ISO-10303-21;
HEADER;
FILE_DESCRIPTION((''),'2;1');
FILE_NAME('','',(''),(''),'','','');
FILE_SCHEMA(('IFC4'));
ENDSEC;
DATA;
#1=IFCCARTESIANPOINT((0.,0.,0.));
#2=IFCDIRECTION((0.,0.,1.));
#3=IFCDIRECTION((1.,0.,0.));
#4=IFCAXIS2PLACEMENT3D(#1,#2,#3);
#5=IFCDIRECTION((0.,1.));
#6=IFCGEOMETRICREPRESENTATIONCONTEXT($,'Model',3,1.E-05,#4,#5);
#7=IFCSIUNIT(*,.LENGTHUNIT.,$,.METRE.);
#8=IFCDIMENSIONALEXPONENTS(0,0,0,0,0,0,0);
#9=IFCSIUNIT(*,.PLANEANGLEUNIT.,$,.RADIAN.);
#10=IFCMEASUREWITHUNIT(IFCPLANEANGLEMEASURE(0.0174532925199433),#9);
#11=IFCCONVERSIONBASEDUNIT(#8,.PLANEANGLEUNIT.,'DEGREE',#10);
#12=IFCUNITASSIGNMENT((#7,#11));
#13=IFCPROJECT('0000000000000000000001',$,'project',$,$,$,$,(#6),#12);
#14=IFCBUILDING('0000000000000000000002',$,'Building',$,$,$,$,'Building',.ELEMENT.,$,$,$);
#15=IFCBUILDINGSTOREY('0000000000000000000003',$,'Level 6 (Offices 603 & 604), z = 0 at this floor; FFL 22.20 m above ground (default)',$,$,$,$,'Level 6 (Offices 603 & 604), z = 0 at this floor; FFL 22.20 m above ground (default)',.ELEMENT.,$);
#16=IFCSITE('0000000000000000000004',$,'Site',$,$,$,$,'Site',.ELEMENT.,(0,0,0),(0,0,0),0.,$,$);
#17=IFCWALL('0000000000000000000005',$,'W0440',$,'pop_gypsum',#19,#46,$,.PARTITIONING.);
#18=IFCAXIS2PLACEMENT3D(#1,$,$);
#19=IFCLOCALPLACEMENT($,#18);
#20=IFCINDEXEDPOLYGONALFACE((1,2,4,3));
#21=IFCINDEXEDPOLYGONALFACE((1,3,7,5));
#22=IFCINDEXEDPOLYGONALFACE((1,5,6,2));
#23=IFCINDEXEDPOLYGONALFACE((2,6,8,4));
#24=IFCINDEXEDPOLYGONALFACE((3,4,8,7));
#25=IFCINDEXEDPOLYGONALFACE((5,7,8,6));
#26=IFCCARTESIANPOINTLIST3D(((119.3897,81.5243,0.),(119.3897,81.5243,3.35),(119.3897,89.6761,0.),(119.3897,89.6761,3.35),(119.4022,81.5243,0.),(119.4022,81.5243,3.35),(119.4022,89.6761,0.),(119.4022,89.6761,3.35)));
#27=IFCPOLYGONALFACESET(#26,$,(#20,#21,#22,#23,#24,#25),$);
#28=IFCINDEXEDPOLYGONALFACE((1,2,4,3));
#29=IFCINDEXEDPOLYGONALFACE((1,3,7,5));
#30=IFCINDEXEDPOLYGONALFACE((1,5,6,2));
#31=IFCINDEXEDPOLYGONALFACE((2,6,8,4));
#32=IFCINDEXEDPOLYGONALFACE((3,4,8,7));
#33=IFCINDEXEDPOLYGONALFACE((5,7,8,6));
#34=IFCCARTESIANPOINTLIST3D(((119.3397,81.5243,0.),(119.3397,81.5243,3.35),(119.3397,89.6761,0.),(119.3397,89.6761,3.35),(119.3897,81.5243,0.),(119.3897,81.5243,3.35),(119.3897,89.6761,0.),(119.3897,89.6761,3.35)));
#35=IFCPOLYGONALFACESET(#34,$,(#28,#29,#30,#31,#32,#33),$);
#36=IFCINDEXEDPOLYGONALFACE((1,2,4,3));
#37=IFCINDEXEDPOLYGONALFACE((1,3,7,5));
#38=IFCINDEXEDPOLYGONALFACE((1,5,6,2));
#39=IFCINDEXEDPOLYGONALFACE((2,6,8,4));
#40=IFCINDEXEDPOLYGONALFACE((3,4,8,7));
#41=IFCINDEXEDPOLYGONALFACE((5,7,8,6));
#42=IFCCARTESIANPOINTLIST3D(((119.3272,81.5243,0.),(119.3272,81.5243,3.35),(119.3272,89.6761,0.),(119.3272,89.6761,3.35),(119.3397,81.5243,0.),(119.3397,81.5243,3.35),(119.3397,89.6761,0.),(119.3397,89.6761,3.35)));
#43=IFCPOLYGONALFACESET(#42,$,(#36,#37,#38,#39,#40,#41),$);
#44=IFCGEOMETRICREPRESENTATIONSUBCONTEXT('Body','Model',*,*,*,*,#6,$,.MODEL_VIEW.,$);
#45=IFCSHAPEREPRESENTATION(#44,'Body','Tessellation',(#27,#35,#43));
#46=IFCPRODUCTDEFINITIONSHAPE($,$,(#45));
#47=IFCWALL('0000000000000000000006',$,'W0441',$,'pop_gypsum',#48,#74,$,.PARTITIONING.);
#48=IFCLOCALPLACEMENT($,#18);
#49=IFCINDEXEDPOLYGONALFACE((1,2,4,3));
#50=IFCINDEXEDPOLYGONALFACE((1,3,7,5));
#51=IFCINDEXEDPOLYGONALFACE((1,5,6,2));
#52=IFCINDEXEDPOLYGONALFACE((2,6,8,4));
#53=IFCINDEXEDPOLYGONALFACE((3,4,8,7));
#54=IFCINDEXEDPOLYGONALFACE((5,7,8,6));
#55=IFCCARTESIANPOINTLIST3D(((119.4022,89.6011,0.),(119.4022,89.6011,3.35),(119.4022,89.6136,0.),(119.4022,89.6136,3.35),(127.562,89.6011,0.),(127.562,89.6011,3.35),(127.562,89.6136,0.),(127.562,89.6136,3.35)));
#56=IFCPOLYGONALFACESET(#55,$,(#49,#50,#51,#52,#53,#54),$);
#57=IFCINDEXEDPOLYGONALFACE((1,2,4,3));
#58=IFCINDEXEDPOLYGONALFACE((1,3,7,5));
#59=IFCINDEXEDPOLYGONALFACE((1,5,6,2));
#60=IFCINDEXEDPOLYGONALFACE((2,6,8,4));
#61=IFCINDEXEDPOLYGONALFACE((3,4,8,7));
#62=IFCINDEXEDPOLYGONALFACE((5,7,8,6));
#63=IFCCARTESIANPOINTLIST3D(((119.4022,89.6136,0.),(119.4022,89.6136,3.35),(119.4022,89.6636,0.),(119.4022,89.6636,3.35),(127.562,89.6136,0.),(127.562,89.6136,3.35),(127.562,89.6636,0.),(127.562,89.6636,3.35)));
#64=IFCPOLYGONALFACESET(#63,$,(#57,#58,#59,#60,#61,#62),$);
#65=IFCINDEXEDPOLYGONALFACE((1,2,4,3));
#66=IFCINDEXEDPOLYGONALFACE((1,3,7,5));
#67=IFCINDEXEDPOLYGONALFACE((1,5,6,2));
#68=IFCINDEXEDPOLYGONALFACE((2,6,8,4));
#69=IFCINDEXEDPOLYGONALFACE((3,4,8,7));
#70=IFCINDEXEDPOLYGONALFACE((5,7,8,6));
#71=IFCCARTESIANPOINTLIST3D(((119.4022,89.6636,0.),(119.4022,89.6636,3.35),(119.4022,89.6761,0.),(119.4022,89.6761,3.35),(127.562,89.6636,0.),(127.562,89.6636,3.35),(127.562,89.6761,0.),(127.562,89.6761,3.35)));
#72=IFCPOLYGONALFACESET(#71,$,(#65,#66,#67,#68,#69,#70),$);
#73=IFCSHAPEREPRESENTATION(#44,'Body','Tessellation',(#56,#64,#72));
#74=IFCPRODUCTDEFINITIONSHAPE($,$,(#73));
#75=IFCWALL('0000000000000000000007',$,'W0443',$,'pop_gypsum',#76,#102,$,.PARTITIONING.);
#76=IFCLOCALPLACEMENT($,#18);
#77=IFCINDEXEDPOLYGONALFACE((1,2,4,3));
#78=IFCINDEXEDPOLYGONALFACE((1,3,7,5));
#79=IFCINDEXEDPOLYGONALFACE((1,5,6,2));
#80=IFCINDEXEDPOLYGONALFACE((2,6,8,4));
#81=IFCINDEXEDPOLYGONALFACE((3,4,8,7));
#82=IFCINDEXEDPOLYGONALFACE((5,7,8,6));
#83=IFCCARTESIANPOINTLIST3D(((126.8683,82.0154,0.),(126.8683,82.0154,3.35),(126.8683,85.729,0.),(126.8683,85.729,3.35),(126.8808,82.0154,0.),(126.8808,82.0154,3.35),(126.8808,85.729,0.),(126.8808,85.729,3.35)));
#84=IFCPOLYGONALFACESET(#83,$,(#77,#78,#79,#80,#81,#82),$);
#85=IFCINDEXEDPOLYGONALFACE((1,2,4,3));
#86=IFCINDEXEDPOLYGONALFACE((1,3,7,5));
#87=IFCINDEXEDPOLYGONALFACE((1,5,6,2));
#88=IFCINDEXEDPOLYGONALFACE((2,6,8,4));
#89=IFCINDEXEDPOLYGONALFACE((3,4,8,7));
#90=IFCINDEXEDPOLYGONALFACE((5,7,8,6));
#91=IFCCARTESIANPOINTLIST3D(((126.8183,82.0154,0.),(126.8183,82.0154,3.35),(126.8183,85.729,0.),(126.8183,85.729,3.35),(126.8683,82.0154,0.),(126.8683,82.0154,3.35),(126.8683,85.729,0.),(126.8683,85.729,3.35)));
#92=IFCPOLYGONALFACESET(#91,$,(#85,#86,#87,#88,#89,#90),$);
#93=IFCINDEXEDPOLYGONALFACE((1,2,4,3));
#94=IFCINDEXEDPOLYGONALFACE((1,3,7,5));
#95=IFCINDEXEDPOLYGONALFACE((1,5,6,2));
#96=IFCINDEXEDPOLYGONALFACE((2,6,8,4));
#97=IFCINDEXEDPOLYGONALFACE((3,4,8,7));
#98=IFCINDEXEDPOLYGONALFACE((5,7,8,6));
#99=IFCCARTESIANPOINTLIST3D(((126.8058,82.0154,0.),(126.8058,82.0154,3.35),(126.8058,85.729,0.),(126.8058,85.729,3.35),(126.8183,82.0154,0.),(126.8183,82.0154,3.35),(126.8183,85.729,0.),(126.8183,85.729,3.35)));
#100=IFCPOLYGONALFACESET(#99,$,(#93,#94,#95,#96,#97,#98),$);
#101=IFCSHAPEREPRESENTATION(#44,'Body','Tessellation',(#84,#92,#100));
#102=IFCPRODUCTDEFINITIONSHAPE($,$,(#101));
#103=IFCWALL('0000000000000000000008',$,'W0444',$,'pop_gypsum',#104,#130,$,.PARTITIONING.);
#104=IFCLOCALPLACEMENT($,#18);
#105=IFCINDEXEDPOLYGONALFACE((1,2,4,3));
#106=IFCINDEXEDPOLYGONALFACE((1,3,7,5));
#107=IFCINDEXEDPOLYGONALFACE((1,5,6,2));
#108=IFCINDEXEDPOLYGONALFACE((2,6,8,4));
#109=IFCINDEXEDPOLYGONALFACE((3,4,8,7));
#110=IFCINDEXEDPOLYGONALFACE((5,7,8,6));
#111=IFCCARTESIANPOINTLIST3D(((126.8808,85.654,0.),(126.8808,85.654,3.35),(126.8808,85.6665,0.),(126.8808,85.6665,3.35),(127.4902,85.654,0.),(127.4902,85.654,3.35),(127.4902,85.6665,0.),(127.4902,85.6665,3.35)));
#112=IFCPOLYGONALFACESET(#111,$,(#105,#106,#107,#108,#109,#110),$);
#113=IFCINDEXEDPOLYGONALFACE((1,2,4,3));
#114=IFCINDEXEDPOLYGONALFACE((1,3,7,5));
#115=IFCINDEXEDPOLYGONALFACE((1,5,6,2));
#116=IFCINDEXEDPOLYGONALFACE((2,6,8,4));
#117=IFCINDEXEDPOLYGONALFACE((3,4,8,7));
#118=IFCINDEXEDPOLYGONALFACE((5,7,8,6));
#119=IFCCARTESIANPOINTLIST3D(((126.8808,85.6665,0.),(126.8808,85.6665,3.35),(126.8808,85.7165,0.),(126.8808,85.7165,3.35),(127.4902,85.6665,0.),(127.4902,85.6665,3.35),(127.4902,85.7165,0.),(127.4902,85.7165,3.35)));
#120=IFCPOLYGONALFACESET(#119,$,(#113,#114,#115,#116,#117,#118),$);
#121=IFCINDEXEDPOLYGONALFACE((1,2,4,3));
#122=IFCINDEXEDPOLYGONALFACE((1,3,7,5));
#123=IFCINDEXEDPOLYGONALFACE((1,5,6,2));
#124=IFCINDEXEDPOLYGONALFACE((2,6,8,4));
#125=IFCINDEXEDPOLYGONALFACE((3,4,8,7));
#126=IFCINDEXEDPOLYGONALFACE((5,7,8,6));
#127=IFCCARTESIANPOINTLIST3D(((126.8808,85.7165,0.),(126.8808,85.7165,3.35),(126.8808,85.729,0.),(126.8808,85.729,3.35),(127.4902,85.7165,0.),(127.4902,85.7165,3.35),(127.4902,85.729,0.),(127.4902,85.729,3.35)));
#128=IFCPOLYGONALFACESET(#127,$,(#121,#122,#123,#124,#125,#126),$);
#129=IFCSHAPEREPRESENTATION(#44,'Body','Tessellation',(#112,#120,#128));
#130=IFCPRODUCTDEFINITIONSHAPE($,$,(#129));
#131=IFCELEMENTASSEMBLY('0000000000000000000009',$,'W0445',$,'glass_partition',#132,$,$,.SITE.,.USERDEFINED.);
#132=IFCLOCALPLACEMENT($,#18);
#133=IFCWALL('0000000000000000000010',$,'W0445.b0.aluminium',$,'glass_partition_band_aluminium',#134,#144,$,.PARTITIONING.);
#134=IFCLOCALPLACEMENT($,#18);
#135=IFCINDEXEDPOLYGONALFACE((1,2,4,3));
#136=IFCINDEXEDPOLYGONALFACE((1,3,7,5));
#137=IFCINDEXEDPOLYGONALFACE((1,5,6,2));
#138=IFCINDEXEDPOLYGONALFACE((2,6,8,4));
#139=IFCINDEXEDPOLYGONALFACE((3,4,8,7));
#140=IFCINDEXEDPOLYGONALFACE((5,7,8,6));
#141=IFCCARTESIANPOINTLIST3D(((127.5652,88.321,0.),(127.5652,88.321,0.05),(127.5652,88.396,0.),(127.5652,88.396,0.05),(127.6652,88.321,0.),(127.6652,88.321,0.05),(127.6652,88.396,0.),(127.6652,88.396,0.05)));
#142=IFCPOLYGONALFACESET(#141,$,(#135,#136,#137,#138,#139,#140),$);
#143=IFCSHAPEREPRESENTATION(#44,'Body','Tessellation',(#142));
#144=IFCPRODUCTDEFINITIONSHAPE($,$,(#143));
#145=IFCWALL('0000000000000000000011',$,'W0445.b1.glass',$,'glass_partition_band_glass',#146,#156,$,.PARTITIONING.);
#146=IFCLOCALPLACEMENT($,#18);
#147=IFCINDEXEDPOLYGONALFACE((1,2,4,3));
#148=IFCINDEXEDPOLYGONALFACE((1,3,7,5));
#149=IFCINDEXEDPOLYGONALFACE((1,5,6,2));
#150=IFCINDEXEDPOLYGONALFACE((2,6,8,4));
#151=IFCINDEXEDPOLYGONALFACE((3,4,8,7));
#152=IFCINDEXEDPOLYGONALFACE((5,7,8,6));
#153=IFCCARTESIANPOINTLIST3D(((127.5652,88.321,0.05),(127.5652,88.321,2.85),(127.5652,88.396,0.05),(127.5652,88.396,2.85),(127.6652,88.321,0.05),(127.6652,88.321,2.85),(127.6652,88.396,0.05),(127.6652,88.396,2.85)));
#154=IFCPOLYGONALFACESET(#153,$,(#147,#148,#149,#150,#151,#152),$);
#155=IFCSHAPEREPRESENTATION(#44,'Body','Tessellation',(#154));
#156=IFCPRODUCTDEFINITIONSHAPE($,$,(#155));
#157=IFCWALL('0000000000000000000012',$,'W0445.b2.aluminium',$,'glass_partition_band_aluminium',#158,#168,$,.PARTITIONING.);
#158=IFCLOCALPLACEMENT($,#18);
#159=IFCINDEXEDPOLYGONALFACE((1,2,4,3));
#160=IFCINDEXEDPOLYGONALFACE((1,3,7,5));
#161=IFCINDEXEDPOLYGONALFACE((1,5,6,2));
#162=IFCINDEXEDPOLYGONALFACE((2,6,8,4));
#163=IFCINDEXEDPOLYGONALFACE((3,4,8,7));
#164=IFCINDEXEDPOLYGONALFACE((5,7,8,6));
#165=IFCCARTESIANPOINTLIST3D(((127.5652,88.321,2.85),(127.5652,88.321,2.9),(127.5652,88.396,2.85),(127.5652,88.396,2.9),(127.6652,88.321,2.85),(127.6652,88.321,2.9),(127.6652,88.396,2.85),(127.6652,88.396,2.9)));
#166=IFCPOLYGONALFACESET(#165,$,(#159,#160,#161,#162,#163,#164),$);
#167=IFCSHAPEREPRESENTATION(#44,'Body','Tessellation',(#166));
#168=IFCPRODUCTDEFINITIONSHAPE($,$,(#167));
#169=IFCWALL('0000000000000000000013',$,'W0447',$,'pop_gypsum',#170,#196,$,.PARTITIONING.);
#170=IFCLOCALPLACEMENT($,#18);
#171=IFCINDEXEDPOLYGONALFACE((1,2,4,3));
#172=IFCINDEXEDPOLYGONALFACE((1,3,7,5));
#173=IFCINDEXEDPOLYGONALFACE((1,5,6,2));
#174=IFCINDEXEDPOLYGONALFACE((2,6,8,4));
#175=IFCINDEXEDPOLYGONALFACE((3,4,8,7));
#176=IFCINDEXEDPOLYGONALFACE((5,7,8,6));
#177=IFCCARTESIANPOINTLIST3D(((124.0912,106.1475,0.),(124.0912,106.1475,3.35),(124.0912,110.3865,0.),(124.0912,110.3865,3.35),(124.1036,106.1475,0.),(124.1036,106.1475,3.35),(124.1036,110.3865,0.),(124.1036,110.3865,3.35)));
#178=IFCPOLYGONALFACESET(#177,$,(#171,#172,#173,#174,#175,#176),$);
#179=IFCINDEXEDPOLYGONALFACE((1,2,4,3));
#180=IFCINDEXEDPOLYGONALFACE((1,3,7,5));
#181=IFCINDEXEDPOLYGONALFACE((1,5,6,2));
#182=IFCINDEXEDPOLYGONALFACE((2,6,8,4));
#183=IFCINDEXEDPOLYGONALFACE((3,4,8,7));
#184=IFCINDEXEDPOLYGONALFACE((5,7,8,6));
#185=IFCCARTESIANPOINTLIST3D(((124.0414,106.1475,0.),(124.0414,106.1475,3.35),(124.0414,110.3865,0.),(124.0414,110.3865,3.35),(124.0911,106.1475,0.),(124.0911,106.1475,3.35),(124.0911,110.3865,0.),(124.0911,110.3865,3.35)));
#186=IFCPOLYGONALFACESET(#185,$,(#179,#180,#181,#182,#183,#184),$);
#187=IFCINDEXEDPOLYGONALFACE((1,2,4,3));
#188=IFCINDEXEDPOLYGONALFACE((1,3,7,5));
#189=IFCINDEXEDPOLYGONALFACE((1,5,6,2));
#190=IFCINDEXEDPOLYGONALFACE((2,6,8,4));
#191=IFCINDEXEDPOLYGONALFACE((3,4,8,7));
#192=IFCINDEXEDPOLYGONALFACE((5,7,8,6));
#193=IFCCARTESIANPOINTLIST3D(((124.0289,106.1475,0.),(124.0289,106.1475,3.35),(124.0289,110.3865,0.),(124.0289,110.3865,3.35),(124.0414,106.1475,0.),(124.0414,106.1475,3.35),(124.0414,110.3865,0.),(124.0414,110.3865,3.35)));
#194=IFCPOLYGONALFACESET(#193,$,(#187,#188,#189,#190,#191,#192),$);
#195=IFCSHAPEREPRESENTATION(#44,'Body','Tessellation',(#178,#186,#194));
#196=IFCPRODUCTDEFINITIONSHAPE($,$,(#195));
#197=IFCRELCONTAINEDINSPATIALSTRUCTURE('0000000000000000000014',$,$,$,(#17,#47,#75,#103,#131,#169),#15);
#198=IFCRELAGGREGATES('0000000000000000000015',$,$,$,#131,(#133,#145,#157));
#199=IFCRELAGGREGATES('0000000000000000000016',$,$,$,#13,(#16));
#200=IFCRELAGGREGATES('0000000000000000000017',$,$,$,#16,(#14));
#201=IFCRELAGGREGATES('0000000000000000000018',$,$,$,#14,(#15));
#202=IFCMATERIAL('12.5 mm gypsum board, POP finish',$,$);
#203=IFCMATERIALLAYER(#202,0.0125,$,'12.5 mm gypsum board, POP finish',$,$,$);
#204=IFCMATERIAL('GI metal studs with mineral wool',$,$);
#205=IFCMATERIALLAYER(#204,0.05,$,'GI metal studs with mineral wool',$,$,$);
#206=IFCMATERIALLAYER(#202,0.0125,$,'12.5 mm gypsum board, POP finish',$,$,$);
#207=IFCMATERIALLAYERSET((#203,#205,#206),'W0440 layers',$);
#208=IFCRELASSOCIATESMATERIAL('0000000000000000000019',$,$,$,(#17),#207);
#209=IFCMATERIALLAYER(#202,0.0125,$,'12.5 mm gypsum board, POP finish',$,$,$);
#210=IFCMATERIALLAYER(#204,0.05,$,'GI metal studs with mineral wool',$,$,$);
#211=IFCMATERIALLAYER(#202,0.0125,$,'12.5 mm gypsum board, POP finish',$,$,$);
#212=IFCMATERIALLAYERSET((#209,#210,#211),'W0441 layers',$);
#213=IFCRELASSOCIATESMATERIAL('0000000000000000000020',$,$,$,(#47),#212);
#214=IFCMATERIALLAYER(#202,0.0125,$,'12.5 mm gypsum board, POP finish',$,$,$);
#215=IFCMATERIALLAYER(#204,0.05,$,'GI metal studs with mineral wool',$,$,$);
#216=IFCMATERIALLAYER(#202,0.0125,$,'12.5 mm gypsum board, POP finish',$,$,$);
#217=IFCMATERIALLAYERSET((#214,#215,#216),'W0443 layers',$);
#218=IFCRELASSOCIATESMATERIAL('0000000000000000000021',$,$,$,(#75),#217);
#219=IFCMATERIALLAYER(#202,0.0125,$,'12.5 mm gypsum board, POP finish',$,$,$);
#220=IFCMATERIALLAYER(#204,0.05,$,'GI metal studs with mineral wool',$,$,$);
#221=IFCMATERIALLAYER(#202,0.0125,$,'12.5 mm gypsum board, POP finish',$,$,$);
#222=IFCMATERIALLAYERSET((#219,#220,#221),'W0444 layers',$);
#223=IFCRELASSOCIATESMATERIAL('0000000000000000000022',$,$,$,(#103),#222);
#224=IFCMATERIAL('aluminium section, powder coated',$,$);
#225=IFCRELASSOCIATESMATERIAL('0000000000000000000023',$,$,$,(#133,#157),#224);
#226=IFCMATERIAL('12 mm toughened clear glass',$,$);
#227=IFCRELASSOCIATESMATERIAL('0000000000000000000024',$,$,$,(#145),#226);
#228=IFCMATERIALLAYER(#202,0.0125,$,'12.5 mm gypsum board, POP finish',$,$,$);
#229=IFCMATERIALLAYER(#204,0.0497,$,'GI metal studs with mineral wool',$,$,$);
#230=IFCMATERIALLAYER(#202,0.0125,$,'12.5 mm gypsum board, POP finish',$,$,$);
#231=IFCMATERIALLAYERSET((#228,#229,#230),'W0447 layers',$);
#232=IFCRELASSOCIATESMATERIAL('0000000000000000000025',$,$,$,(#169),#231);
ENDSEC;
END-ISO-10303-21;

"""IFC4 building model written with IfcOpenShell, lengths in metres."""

from ifc_helpers import new_model, entity, si_unit, converted_unit, direction, frame, frame_2d, origin_with_axes, origin_2d_with_axis, place, context, subcontext, project, spatial, rectangle, extrude, material, layer, layer_set, layer_usage, element, aggregate, save


model = new_model("IFC4")

# Units and contexts
model_context = context("Model", 3, precision=1e-05, world=origin_with_axes(), true_north=direction((0.0, 1.0)))
body_context = subcontext(model_context, "Body", "Model", "MODEL_VIEW")
ifc_project = project(units=[si_unit("LENGTHUNIT", "METRE"), converted_unit("PLANEANGLEUNIT", "DEGREE", entity("IfcPlaneAngleMeasure", 0.0174532925199433), si_unit("PLANEANGLEUNIT", "RADIAN"), dimensions=[0, 0, 0, 0, 0, 0, 0])], contexts=[model_context])

# Site, building, storey
site = spatial("IfcSite", under=ifc_project, Name="Site", LongName="Site", CompositionType="ELEMENT", RefLatitude=(0, 0, 0), RefLongitude=(0, 0, 0), RefElevation=0.0)
building = spatial("IfcBuilding", under=site, Name="Building", LongName="Building", CompositionType="ELEMENT")
storey = spatial("IfcBuildingStorey", under=building, Name="Level 6 (Offices 603 & 604), z = 0 at this floor; FFL 22.20 m above ground (default)", LongName="Level 6 (Offices 603 & 604), z = 0 at this floor; FFL 22.20 m above ground (default)", CompositionType="ELEMENT")

# Shared definitions
ifc_material_1 = material(Name="aluminium section, powder coated")
placement = place(None, origin_with_axes())

# Shared definitions
ifc_material_2 = material(Name="12.5 mm gypsum board, POP finish")
ifc_material_3 = material(Name="GI metal studs with mineral wool")

# Shared definitions
ifc_material_4 = material(Name="12 mm toughened clear glass")

# Walls
ifc_layer_1 = layer(ifc_material_2, 0.0125, Name="12.5 mm gypsum board, POP finish")
ifc_layer_2 = layer(ifc_material_3, 0.05, Name="GI metal studs with mineral wool")
ifc_layer_3 = layer(ifc_material_2, 0.0125, Name="12.5 mm gypsum board, POP finish")
ifc_layer_set_1 = layer_set([ifc_layer_1, ifc_layer_2, ifc_layer_3], Name="W0440 layers")
ifc_layer_usage_1 = layer_usage(ifc_layer_set_1, "AXIS2", "POSITIVE", -0.0375)
element("IfcWall", 1, at=placement, inside=storey, material=ifc_layer_usage_1, Name="W0440", ObjectType="pop_gypsum", PredefinedType="PARTITIONING", context=body_context, shape_type="SweptSolid", body=[
    extrude(rectangle(XDim=8.1518, YDim=0.0125, at=frame_2d((0.0, 0.0), x_axis=(0.0, 1.0))), frame((119.3959, 85.6002, 0.0), z_axis=(0.0, 0.0, 1.0), x_axis=(1.0, 0.0, 0.0)), (0.0, 0.0, 1.0), 3.35),
    extrude(rectangle(XDim=8.1518, YDim=0.05, at=frame_2d((-0.0312, 0.0), x_axis=(0.0, 1.0))), frame((119.3959, 85.6002, 0.0), z_axis=(0.0, 0.0, 1.0), x_axis=(1.0, 0.0, 0.0)), (0.0, 0.0, 1.0), 3.35),
    extrude(rectangle(XDim=8.1518, YDim=0.0125, at=frame_2d((-0.0625, 0.0), x_axis=(0.0, 1.0))), frame((119.3959, 85.6002, 0.0), z_axis=(0.0, 0.0, 1.0), x_axis=(1.0, 0.0, 0.0)), (0.0, 0.0, 1.0), 3.35),
])
ifc_layer_4 = layer(ifc_material_2, 0.0125, Name="12.5 mm gypsum board, POP finish")
ifc_layer_5 = layer(ifc_material_3, 0.05, Name="GI metal studs with mineral wool")
ifc_layer_6 = layer(ifc_material_2, 0.0125, Name="12.5 mm gypsum board, POP finish")
ifc_layer_set_2 = layer_set([ifc_layer_4, ifc_layer_5, ifc_layer_6], Name="W0441 layers")
ifc_layer_usage_2 = layer_usage(ifc_layer_set_2, "AXIS2", "POSITIVE", -0.0375)
element("IfcWall", 2, at=placement, inside=storey, material=ifc_layer_usage_2, Name="W0441", ObjectType="pop_gypsum", PredefinedType="PARTITIONING", context=body_context, shape_type="SweptSolid", body=[
    extrude(rectangle(XDim=8.1598, YDim=0.0125, at=frame_2d((0.0, 0.0), x_axis=(1.0, 0.0))), frame((123.4821, 89.6073, 0.0), z_axis=(0.0, 0.0, 1.0), x_axis=(1.0, 0.0, 0.0)), (0.0, 0.0, 1.0), 3.35),
    extrude(rectangle(XDim=8.1598, YDim=0.05, at=frame_2d((0.0, 0.0312), x_axis=(1.0, 0.0))), frame((123.4821, 89.6073, 0.0), z_axis=(0.0, 0.0, 1.0), x_axis=(1.0, 0.0, 0.0)), (0.0, 0.0, 1.0), 3.35),
    extrude(rectangle(XDim=8.1598, YDim=0.0125, at=frame_2d((0.0, 0.0625), x_axis=(1.0, 0.0))), frame((123.4821, 89.6073, 0.0), z_axis=(0.0, 0.0, 1.0), x_axis=(1.0, 0.0, 0.0)), (0.0, 0.0, 1.0), 3.35),
])
ifc_layer_7 = layer(ifc_material_2, 0.0125, Name="12.5 mm gypsum board, POP finish")
ifc_layer_8 = layer(ifc_material_3, 0.05, Name="GI metal studs with mineral wool")
ifc_layer_9 = layer(ifc_material_2, 0.0125, Name="12.5 mm gypsum board, POP finish")
ifc_layer_set_3 = layer_set([ifc_layer_7, ifc_layer_8, ifc_layer_9], Name="W0443 layers")
ifc_layer_usage_3 = layer_usage(ifc_layer_set_3, "AXIS2", "POSITIVE", -0.0375)
element("IfcWall", 3, at=placement, inside=storey, material=ifc_layer_usage_3, Name="W0443", ObjectType="pop_gypsum", PredefinedType="PARTITIONING", context=body_context, shape_type="SweptSolid", body=[
    extrude(rectangle(XDim=3.7136, YDim=0.0125, at=frame_2d((0.0, 0.0), x_axis=(0.0, 1.0))), frame((126.8745, 83.8722, 0.0), z_axis=(0.0, 0.0, 1.0), x_axis=(1.0, 0.0, 0.0)), (0.0, 0.0, 1.0), 3.35),
    extrude(rectangle(XDim=3.7136, YDim=0.05, at=frame_2d((-0.0312, 0.0), x_axis=(0.0, 1.0))), frame((126.8745, 83.8722, 0.0), z_axis=(0.0, 0.0, 1.0), x_axis=(1.0, 0.0, 0.0)), (0.0, 0.0, 1.0), 3.35),
    extrude(rectangle(XDim=3.7136, YDim=0.0125, at=frame_2d((-0.0625, 0.0), x_axis=(0.0, 1.0))), frame((126.8745, 83.8722, 0.0), z_axis=(0.0, 0.0, 1.0), x_axis=(1.0, 0.0, 0.0)), (0.0, 0.0, 1.0), 3.35),
])
ifc_layer_10 = layer(ifc_material_2, 0.0125, Name="12.5 mm gypsum board, POP finish")
ifc_layer_11 = layer(ifc_material_3, 0.05, Name="GI metal studs with mineral wool")
ifc_layer_12 = layer(ifc_material_2, 0.0125, Name="12.5 mm gypsum board, POP finish")
ifc_layer_set_4 = layer_set([ifc_layer_10, ifc_layer_11, ifc_layer_12], Name="W0444 layers")
ifc_layer_usage_4 = layer_usage(ifc_layer_set_4, "AXIS2", "POSITIVE", -0.0375)
element("IfcWall", 4, at=placement, inside=storey, material=ifc_layer_usage_4, Name="W0444", ObjectType="pop_gypsum", PredefinedType="PARTITIONING", context=body_context, shape_type="SweptSolid", body=[
    extrude(rectangle(XDim=0.6094, YDim=0.0125, at=origin_2d_with_axis()), frame((127.1855, 85.6603, 0.0), z_axis=(0.0, 0.0, 1.0), x_axis=(1.0, 0.0, 0.0)), (0.0, 0.0, 1.0), 3.35),
    extrude(rectangle(XDim=0.6094, YDim=0.05, at=frame_2d((0.0, 0.0313), x_axis=(1.0, 0.0))), frame((127.1855, 85.6603, 0.0), z_axis=(0.0, 0.0, 1.0), x_axis=(1.0, 0.0, 0.0)), (0.0, 0.0, 1.0), 3.35),
    extrude(rectangle(XDim=0.6094, YDim=0.0125, at=frame_2d((0.0, 0.0625), x_axis=(1.0, 0.0))), frame((127.1855, 85.6603, 0.0), z_axis=(0.0, 0.0, 1.0), x_axis=(1.0, 0.0, 0.0)), (0.0, 0.0, 1.0), 3.35),
])

# Element assembly, walls
assembly_1 = element("IfcElementAssembly", 5, inside=storey, Name="W0445", ObjectType="glass_partition", AssemblyPlace="SITE", PredefinedType="USERDEFINED")
wall_1 = element("IfcWall", 6, at=placement, material=ifc_material_1, Name="W0445.b0.aluminium", ObjectType="glass_partition_band_aluminium", PredefinedType="PARTITIONING", context=body_context, shape_type="SweptSolid", body=[
    extrude(rectangle(XDim=0.1, YDim=0.075, at=frame_2d((0.0, 0.0), x_axis=(1.0, 0.0))), frame((127.6152, 88.3585, 0.0), z_axis=(0.0, 0.0, 1.0), x_axis=(1.0, 0.0, 0.0)), (0.0, 0.0, 1.0), 0.05),
])
wall_2 = element("IfcWall", 7, at=placement, material=ifc_material_4, Name="W0445.b1.glass", ObjectType="glass_partition_band_glass", PredefinedType="PARTITIONING", context=body_context, shape_type="SweptSolid", body=[
    extrude(rectangle(XDim=0.1, YDim=0.075, at=frame_2d((0.0, 0.0), x_axis=(1.0, 0.0))), frame((127.6152, 88.3585, 0.05), z_axis=(0.0, 0.0, 1.0), x_axis=(1.0, 0.0, 0.0)), (0.0, 0.0, 1.0), 2.8),
])
wall_3 = element("IfcWall", 8, at=placement, material=ifc_material_1, Name="W0445.b2.aluminium", ObjectType="glass_partition_band_aluminium", PredefinedType="PARTITIONING", context=body_context, shape_type="SweptSolid", body=[
    extrude(rectangle(XDim=0.1, YDim=0.075, at=frame_2d((0.0, 0.0), x_axis=(1.0, 0.0))), frame((127.6152, 88.3585, 2.85), z_axis=(0.0, 0.0, 1.0), x_axis=(1.0, 0.0, 0.0)), (0.0, 0.0, 1.0), 0.05),
])
aggregate(assembly_1, [wall_1, wall_2, wall_3])

# Wall
ifc_layer_13 = layer(ifc_material_2, 0.0125, Name="12.5 mm gypsum board, POP finish")
ifc_layer_14 = layer(ifc_material_3, 0.0497, Name="GI metal studs with mineral wool")
ifc_layer_15 = layer(ifc_material_2, 0.0125, Name="12.5 mm gypsum board, POP finish")
ifc_layer_set_5 = layer_set([ifc_layer_13, ifc_layer_14, ifc_layer_15], Name="W0447 layers")
ifc_layer_usage_5 = layer_usage(ifc_layer_set_5, "AXIS2", "POSITIVE", -0.0374)
element("IfcWall", 9, at=placement, inside=storey, material=ifc_layer_usage_5, Name="W0447", ObjectType="pop_gypsum", PredefinedType="PARTITIONING", context=body_context, shape_type="SweptSolid", body=[
    extrude(rectangle(XDim=4.239, YDim=0.0125, at=frame_2d((0.0, 0.0), x_axis=(0.0, 1.0))), frame((124.0974, 108.267, 0.0), z_axis=(0.0, 0.0, 1.0), x_axis=(1.0, 0.0, 0.0)), (0.0, 0.0, 1.0), 3.35),
    extrude(rectangle(XDim=4.239, YDim=0.0497, at=frame_2d((-0.0311, 0.0), x_axis=(0.0, 1.0))), frame((124.0974, 108.267, 0.0), z_axis=(0.0, 0.0, 1.0), x_axis=(1.0, 0.0, 0.0)), (0.0, 0.0, 1.0), 3.35),
    extrude(rectangle(XDim=4.239, YDim=0.0125, at=frame_2d((-0.0622, 0.0), x_axis=(0.0, 1.0))), frame((124.0974, 108.267, 0.0), z_axis=(0.0, 0.0, 1.0), x_axis=(1.0, 0.0, 0.0)), (0.0, 0.0, 1.0), 3.35),
])

save(model, "model.ifc")
